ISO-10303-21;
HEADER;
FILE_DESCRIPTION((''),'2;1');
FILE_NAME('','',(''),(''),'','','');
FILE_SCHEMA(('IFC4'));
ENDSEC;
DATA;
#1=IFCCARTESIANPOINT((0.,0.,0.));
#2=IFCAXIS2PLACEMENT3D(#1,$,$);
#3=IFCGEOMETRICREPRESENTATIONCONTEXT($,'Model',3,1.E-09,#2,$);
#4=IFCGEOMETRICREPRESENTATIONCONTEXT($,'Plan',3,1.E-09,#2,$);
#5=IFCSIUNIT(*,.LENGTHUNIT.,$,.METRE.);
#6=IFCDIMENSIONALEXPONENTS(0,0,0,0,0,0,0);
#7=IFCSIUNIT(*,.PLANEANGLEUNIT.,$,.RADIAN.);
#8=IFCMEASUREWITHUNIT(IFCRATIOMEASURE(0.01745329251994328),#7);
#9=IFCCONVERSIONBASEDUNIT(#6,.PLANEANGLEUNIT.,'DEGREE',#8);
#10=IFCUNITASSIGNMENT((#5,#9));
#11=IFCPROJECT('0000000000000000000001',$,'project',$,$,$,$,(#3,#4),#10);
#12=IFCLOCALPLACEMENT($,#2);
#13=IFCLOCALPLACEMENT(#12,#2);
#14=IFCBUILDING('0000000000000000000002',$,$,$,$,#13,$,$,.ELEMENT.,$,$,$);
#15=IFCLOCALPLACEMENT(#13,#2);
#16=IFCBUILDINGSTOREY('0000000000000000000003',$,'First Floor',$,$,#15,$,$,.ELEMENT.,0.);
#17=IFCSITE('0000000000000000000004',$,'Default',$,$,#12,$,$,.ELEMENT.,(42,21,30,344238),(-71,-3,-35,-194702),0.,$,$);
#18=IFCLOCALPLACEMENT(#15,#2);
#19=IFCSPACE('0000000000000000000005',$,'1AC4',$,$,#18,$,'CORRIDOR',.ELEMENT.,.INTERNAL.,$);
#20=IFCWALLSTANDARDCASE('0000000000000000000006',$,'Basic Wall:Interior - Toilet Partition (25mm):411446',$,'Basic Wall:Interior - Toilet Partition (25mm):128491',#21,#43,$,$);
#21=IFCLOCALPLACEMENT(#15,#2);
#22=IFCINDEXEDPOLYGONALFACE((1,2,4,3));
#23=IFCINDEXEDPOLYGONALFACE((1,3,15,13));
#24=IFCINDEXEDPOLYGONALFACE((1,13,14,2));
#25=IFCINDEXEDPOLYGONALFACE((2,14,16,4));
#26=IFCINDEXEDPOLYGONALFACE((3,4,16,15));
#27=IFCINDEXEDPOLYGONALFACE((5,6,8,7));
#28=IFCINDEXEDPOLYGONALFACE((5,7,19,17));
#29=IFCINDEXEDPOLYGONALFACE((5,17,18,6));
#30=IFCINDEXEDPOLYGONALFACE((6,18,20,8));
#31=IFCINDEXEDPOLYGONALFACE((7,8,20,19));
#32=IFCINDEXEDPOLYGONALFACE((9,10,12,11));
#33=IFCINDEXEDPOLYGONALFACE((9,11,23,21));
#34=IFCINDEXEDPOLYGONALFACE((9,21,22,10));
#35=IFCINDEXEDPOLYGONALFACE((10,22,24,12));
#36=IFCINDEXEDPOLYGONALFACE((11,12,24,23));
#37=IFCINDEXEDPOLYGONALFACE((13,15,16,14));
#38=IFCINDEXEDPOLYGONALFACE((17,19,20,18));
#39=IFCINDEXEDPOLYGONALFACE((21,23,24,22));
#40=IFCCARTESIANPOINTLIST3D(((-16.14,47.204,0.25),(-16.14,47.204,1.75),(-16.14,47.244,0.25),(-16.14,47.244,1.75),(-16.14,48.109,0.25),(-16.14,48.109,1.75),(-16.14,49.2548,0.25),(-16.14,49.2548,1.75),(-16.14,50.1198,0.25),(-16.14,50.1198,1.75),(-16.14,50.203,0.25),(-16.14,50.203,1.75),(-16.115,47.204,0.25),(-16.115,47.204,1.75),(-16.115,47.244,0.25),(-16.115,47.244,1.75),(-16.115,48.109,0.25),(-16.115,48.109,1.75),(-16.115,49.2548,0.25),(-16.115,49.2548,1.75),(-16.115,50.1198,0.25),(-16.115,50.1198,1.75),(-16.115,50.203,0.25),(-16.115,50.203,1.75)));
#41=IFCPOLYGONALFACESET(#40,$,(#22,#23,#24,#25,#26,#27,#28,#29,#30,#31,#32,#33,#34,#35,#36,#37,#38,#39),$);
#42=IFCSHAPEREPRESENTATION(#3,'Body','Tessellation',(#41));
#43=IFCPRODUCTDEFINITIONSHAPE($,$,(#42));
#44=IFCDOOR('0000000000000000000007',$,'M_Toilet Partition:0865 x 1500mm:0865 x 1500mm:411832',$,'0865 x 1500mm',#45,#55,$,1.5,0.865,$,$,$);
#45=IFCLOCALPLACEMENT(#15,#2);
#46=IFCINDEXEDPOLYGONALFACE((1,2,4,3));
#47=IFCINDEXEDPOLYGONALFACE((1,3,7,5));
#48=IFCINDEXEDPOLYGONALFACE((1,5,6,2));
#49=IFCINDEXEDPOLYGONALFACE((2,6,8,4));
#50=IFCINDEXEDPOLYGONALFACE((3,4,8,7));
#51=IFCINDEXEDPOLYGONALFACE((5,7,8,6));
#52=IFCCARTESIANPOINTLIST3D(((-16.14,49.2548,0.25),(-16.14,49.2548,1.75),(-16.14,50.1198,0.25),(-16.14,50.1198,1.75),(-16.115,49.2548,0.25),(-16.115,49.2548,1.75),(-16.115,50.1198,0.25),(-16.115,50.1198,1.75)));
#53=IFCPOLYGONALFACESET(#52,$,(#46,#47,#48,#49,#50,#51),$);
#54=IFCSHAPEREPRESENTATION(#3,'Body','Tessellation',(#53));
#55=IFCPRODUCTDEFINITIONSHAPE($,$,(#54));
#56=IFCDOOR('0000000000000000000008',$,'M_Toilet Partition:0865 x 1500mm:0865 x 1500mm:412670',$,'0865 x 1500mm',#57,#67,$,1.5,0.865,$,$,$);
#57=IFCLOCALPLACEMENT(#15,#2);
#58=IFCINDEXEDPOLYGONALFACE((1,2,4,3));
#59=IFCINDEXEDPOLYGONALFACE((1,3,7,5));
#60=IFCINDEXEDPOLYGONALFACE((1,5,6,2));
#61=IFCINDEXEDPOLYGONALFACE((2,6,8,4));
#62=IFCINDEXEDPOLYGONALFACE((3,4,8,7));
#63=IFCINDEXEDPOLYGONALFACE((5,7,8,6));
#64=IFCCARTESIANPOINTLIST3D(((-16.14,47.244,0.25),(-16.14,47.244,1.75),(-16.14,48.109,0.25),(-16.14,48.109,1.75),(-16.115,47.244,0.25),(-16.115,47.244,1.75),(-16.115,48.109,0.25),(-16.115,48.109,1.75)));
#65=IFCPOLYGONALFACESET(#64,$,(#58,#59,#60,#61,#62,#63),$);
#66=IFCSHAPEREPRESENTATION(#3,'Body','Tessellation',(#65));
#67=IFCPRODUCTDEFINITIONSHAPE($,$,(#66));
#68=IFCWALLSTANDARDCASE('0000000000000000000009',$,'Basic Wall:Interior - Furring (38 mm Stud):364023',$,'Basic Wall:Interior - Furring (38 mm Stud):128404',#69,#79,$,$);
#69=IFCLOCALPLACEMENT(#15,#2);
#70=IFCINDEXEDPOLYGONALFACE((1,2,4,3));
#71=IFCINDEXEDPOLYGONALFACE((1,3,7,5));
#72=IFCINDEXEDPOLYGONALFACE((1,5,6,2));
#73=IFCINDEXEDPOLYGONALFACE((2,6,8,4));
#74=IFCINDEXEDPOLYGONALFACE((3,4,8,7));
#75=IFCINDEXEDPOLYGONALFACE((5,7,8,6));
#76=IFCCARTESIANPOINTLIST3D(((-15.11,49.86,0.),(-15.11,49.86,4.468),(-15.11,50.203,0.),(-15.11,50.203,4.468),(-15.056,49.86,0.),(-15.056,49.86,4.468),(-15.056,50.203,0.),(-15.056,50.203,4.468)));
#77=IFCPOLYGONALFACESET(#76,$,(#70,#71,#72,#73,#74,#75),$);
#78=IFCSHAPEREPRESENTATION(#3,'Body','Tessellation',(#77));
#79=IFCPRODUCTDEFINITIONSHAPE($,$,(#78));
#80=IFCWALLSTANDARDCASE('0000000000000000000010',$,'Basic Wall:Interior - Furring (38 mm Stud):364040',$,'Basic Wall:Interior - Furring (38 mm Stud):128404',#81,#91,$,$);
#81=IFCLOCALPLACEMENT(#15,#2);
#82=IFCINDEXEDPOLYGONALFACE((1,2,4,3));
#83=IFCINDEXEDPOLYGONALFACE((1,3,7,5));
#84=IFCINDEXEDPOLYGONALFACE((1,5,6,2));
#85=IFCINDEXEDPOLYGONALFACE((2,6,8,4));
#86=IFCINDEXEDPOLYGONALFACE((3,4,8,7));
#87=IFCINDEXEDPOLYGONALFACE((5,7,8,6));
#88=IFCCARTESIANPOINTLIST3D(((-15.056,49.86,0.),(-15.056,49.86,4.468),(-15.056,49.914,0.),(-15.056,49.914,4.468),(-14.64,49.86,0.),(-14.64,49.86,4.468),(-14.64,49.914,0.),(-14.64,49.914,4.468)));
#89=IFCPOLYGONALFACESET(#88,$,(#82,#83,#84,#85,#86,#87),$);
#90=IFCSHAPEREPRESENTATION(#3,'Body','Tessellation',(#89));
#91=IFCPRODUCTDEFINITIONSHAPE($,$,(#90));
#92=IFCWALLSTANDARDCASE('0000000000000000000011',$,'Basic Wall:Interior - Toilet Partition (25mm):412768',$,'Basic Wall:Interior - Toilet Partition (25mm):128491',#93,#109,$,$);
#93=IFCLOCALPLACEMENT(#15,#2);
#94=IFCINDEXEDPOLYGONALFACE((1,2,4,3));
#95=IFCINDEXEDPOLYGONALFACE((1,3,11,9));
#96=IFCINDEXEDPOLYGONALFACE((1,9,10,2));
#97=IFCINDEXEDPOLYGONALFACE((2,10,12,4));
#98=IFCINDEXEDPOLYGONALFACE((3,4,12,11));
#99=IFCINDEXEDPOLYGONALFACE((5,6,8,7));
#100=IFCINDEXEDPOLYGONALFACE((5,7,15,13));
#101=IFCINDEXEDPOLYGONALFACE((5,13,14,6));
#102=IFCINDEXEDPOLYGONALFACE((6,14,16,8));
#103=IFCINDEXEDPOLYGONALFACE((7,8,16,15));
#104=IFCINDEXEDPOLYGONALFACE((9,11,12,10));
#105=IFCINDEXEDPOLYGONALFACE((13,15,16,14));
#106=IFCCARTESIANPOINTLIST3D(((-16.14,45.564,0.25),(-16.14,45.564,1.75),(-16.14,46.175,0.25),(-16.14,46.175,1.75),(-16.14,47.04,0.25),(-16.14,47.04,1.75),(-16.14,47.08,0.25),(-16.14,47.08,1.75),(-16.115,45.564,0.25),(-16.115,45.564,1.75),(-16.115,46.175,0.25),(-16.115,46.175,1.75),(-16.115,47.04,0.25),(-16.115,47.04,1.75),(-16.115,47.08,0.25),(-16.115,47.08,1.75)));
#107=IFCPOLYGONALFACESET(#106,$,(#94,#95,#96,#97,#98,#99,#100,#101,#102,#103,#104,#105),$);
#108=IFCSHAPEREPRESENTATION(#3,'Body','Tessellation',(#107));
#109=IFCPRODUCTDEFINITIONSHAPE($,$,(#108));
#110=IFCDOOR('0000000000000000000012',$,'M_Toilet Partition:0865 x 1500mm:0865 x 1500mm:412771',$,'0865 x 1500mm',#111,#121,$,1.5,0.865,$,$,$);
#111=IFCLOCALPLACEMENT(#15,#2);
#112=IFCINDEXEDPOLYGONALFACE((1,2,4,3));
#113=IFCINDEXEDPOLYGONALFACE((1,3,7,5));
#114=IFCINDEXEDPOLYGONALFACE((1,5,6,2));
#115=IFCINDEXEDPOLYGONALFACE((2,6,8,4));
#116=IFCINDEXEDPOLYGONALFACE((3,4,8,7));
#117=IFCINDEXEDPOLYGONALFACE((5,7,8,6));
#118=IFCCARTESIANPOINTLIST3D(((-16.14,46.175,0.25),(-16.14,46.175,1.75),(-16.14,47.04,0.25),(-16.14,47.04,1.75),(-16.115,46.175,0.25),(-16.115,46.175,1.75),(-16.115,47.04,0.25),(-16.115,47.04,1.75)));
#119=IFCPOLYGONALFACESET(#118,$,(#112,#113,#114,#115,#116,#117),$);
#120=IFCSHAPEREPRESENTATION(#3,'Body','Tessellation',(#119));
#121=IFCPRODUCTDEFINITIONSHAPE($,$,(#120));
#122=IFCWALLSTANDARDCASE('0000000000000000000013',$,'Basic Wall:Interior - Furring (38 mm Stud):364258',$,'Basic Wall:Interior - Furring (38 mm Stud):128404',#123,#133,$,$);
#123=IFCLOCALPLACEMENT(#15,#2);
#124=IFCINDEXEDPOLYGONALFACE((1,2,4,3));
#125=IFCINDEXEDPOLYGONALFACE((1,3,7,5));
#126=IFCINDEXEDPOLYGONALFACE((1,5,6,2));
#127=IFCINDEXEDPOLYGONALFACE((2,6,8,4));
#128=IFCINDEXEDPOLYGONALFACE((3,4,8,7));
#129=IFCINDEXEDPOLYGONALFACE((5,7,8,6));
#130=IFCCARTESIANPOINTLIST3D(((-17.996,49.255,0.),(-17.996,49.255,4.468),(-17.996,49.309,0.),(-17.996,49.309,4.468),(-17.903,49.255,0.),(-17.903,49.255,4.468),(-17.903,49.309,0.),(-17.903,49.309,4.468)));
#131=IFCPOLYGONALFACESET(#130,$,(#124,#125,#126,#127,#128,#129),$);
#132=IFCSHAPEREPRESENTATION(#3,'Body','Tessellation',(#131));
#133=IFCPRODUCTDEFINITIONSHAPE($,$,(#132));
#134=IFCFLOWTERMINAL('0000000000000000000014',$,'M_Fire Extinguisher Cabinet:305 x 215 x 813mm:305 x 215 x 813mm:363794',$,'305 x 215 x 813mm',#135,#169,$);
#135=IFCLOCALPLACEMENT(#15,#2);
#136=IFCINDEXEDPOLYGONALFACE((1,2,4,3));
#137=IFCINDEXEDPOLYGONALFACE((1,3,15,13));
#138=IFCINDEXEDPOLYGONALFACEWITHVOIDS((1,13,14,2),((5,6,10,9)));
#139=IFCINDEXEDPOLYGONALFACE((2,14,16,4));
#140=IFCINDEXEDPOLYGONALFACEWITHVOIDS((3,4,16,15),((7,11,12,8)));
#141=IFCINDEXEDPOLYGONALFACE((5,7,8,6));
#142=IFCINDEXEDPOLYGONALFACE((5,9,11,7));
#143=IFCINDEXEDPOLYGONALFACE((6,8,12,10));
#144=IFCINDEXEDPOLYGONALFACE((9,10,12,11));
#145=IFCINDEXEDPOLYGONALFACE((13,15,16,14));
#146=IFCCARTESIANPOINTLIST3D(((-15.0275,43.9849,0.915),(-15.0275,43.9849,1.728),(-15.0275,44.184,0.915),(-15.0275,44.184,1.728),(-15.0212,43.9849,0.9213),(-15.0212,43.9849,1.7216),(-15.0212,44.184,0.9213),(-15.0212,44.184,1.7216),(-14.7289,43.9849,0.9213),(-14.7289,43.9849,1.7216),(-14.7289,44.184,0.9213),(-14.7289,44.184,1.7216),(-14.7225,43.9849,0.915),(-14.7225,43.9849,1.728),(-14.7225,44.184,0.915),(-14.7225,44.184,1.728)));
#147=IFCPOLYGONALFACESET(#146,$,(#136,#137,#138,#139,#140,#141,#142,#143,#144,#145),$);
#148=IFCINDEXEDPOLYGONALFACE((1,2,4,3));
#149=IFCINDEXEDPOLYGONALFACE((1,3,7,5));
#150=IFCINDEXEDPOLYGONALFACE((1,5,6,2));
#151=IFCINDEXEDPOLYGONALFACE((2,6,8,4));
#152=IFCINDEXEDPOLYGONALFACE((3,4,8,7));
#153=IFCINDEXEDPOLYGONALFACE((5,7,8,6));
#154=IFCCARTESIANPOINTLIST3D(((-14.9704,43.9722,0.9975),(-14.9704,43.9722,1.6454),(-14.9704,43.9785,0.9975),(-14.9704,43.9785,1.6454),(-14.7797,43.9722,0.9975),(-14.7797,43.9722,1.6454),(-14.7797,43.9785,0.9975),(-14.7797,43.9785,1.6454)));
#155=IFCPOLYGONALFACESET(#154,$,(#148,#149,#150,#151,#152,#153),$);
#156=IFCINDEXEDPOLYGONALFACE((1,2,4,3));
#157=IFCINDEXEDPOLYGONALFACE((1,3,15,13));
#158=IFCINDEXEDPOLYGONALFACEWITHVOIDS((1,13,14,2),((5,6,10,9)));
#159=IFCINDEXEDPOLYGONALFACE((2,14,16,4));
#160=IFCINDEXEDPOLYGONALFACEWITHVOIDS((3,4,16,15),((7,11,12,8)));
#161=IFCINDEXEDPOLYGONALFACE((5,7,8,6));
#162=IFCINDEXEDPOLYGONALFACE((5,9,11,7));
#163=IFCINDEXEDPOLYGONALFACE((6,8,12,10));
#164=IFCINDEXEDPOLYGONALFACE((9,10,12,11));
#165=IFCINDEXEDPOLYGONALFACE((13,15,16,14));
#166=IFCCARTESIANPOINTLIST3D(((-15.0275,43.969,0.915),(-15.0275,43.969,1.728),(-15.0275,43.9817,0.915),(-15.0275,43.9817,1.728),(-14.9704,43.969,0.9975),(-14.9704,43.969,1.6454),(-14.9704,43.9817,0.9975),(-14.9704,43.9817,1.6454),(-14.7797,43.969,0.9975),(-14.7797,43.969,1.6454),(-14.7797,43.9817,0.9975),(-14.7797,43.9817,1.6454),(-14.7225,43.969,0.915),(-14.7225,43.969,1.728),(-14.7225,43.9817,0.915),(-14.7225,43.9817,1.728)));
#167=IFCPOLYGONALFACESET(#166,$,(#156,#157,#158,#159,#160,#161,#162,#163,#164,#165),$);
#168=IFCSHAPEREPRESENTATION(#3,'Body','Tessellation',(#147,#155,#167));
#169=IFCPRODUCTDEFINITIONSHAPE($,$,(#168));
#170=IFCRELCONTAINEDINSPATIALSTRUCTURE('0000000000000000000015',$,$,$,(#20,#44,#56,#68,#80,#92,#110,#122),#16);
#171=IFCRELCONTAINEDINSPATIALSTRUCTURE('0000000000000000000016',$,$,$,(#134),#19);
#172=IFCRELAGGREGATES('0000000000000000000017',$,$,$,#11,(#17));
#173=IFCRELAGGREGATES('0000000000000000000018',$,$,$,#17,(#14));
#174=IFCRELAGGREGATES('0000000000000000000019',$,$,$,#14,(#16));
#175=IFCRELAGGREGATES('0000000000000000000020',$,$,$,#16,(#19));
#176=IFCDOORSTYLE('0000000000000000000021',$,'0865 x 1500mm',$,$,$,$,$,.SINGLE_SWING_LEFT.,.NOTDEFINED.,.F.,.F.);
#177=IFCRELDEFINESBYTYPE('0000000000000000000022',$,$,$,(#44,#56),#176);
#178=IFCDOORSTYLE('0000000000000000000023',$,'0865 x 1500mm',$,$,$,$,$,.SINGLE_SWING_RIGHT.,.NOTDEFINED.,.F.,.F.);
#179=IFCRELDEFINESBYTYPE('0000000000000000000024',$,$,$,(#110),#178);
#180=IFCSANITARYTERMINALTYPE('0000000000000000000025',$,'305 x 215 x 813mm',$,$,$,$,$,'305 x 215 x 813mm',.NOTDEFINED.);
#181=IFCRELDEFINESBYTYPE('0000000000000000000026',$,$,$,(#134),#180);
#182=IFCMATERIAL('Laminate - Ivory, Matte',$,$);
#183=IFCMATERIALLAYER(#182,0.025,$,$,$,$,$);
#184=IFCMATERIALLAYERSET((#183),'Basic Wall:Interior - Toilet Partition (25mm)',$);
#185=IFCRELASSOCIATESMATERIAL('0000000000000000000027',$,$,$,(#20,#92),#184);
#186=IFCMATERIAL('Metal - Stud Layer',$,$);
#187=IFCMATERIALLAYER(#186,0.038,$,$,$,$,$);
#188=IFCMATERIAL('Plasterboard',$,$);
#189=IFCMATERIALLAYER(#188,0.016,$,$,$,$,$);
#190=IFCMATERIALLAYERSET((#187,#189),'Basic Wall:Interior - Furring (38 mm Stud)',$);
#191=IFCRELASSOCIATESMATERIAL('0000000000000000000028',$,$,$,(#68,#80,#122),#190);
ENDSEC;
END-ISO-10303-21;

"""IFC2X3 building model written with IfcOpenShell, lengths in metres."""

from ifc_helpers import new_model, entity, si_unit, converted_unit, frame, frame_2d, origin, origin_2d_with_axis, place, context, project, spatial, polyline, rectangle, outline, extrude, source, transform, mapped, material, layer, layer_set, layer_usage, type_object, type_shapes, element, fill, save


model = new_model("IFC2X3")

# Units and contexts
model_context = context("Model", 3, precision=1e-09, world=origin())
plan_context = context("Plan", 3, precision=1e-09, world=origin())
ifc_project = project(units=[si_unit("LENGTHUNIT", "METRE"), converted_unit("PLANEANGLEUNIT", "DEGREE", entity("IfcRatioMeasure", 0.01745329251994328), si_unit("PLANEANGLEUNIT", "RADIAN"), dimensions=[0, 0, 0, 0, 0, 0, 0])], contexts=[model_context, plan_context])

# Site, building, storey
site_placement = place(None, origin())
site = spatial("IfcSite", under=ifc_project, at=site_placement, Name="Default", CompositionType="ELEMENT", RefLatitude=(42, 21, 30, 344238), RefLongitude=(-71, -3, -35, -194702), RefElevation=0.0)
building_placement = place(site_placement, origin())
building = spatial("IfcBuilding", under=site, at=building_placement, CompositionType="ELEMENT")
storey_placement = place(building_placement, origin())
storey = spatial("IfcBuildingStorey", under=building, at=storey_placement, Name="First Floor", CompositionType="ELEMENT", Elevation=0.0)

# Shared definitions
ifc_material_1 = material(Name="Metal - Stud Layer")
ifc_material_2 = material(Name="Plasterboard")
ifc_layer_1 = layer(ifc_material_2, 0.016)

# Shared definitions
ifc_layer_2 = layer(ifc_material_1, 0.038)
ifc_layer_set_1 = layer_set([ifc_layer_2, ifc_layer_1], Name="Basic Wall:Interior - Furring (38 mm Stud)")
ifc_layer_usage_1 = layer_usage(ifc_layer_set_1, "AXIS2", "NEGATIVE", 0.027)

# Wall, openings, doors
ifc_material_3 = material(Name="Laminate - Ivory, Matte")
ifc_layer_3 = layer(ifc_material_3, 0.025)
ifc_layer_set_2 = layer_set([ifc_layer_3], Name="Basic Wall:Interior - Toilet Partition (25mm)")
ifc_layer_usage_2 = layer_usage(ifc_layer_set_2, "AXIS2", "POSITIVE", -0.0125)
wall_1_placement = place(storey_placement, frame((-16.1275, 50.203, 0.25), z_axis=(0.0, 0.0, 1.0), x_axis=(0.0, -1.0, 0.0)))
wall_1 = element("IfcWallStandardCase", 1, at=wall_1_placement, inside=storey, material=ifc_layer_usage_2, Name="Basic Wall:Interior - Toilet Partition (25mm):411446", ObjectType="Basic Wall:Interior - Toilet Partition (25mm):128491", context=model_context, shape_type="SweptSolid", body=[
    extrude(rectangle(XDim=2.999, YDim=0.025, at=frame_2d((1.4995, 0.0), x_axis=(-1.0, 0.0))), origin(), (0.0, 0.0, 1.0), 1.5),
])
opening_1_placement = place(wall_1_placement, frame((0.0832, -0.0125, 0.0)))
opening_1 = element("IfcOpeningElement", 2, at=opening_1_placement, cuts=wall_1, ObjectType="Opening", context=model_context, shape_type="SweptSolid", body=[
    extrude(rectangle(XDim=0.865, YDim=1.5, at=frame_2d((0.75, 0.4325), x_axis=(0.0, -1.0))), frame((0.0, 0.0, 0.0), z_axis=(0.0, 1.0, 0.0), x_axis=(0.0, 0.0, 1.0)), (0.0, 0.0, 1.0), 0.025),
])
opening_2_placement = place(wall_1_placement, frame((2.959, 0.0125, 0.0)))
opening_2 = element("IfcOpeningElement", 3, at=opening_2_placement, cuts=wall_1, ObjectType="Opening", context=model_context, shape_type="SweptSolid", body=[
    extrude(rectangle(XDim=0.865, YDim=1.5, at=frame_2d((0.75, 0.4325), x_axis=(0.0, -1.0))), frame((0.0, 0.0, 0.0), z_axis=(0.0, -1.0, 0.0), x_axis=(0.0, 0.0, 1.0)), (0.0, 0.0, 1.0), 0.025),
])
door_style_1 = type_object("IfcDoorStyle", Name="0865 x 1500mm", ConstructionType="NOTDEFINED", OperationType="SINGLE_SWING_LEFT", ParameterTakesPrecedence=False, Sizeable=False)
shared_shape_1 = source(origin(), model_context, "Body", "SweptSolid", [
    extrude(rectangle(XDim=0.865, YDim=0.025, at=origin_2d_with_axis()), frame((0.4325, 0.0125, 0.0)), (0.0, 0.0, 1.0), 1.5),
])
type_shapes(door_style_1, [shared_shape_1])
door_1_placement = place(opening_1_placement, origin())
door_1 = element("IfcDoor", 4, at=door_1_placement, inside=storey, type_object=door_style_1, Name="M_Toilet Partition:0865 x 1500mm:0865 x 1500mm:411832", ObjectType="0865 x 1500mm", OverallHeight=1.5, OverallWidth=0.865, context=model_context, shape_type="MappedRepresentation", body=[
    mapped(shared_shape_1, transform((0.0, 0.0, 0.0), scale=1.0)),
])
fill(opening_1, door_1)
door_2_placement = place(opening_2_placement, frame((0.0, 0.0, 0.0), z_axis=(0.0, 0.0, 1.0), x_axis=(-1.0, 0.0, 0.0)))
door_2 = element("IfcDoor", 5, at=door_2_placement, inside=storey, type_object=door_style_1, Name="M_Toilet Partition:0865 x 1500mm:0865 x 1500mm:412670", ObjectType="0865 x 1500mm", OverallHeight=1.5, OverallWidth=0.865, context=model_context, shape_type="MappedRepresentation", body=[
    mapped(shared_shape_1, transform((0.0, 0.0, 0.0), scale=1.0)),
])
fill(opening_2, door_2)

# Walls
wall_2_placement = place(storey_placement, frame((-15.083, 50.203, 0.0), z_axis=(0.0, 0.0, 1.0), x_axis=(0.0, -1.0, 0.0)))
element("IfcWallStandardCase", 6, at=wall_2_placement, inside=storey, material=ifc_layer_usage_1, Name="Basic Wall:Interior - Furring (38 mm Stud):364023", ObjectType="Basic Wall:Interior - Furring (38 mm Stud):128404", context=model_context, shape_type="SweptSolid", body=[
    extrude(rectangle(XDim=0.343, YDim=0.054, at=frame_2d((0.1715, 0.0), x_axis=(-1.0, 0.0))), origin(), (0.0, 0.0, 1.0), 4.468),
])
wall_3_placement = place(storey_placement, frame((-15.056, 49.887, 0.0)))
element("IfcWallStandardCase", 7, at=wall_3_placement, inside=storey, material=ifc_layer_usage_1, Name="Basic Wall:Interior - Furring (38 mm Stud):364040", ObjectType="Basic Wall:Interior - Furring (38 mm Stud):128404", context=model_context, shape_type="SweptSolid", body=[
    extrude(rectangle(XDim=0.416, YDim=0.054, at=frame_2d((0.208, 0.0), x_axis=(-1.0, 0.0))), origin(), (0.0, 0.0, 1.0), 4.468),
])

# Wall, opening, door
ifc_layer_usage_3 = layer_usage(ifc_layer_set_2, "AXIS2", "NEGATIVE", 0.0125)
wall_4_placement = place(storey_placement, frame((-16.1275, 45.564, 0.25), z_axis=(0.0, 0.0, 1.0), x_axis=(0.0, 1.0, 0.0)))
wall_4 = element("IfcWallStandardCase", 8, at=wall_4_placement, inside=storey, material=ifc_layer_usage_3, Name="Basic Wall:Interior - Toilet Partition (25mm):412768", ObjectType="Basic Wall:Interior - Toilet Partition (25mm):128491", context=model_context, shape_type="SweptSolid", body=[
    extrude(rectangle(XDim=1.516, YDim=0.025, at=frame_2d((0.758, 0.0), x_axis=(-1.0, 0.0))), origin(), (0.0, 0.0, 1.0), 1.5),
])
opening_3_placement = place(wall_4_placement, frame((0.611, -0.0125, 0.0)))
opening_3 = element("IfcOpeningElement", 9, at=opening_3_placement, cuts=wall_4, ObjectType="Opening", context=model_context, shape_type="SweptSolid", body=[
    extrude(rectangle(XDim=0.865, YDim=1.5, at=frame_2d((0.75, 0.4325), x_axis=(0.0, 1.0))), frame((0.0, 0.0, 0.0), z_axis=(0.0, 1.0, 0.0), x_axis=(0.0, 0.0, 1.0)), (0.0, 0.0, 1.0), 0.025),
])
door_style_2 = type_object("IfcDoorStyle", Name="0865 x 1500mm", ConstructionType="NOTDEFINED", OperationType="SINGLE_SWING_RIGHT", ParameterTakesPrecedence=False, Sizeable=False)
shared_shape_2 = source(origin(), model_context, "Body", "SweptSolid", [
    extrude(rectangle(XDim=0.025, YDim=0.865, at=origin_2d_with_axis()), frame((0.4325, 0.0125, 0.0), z_axis=(0.0, 0.0, 1.0), x_axis=(0.0, 1.0, 0.0)), (0.0, 0.0, 1.0), 1.5),
])
type_shapes(door_style_2, [shared_shape_2])
door_3_placement = place(opening_3_placement, origin())
door_3 = element("IfcDoor", 10, at=door_3_placement, inside=storey, type_object=door_style_2, Name="M_Toilet Partition:0865 x 1500mm:0865 x 1500mm:412771", ObjectType="0865 x 1500mm", OverallHeight=1.5, OverallWidth=0.865, context=model_context, shape_type="MappedRepresentation", body=[
    mapped(shared_shape_2, transform((0.0, 0.0, 0.0), scale=1.0)),
])
fill(opening_3, door_3)

# Wall
wall_5_placement = place(storey_placement, frame((-17.996, 49.282, 0.0)))
element("IfcWallStandardCase", 11, at=wall_5_placement, inside=storey, material=ifc_layer_usage_1, Name="Basic Wall:Interior - Furring (38 mm Stud):364258", ObjectType="Basic Wall:Interior - Furring (38 mm Stud):128404", context=model_context, shape_type="SweptSolid", body=[
    extrude(rectangle(XDim=0.093, YDim=0.054, at=frame_2d((0.0465, 0.0), x_axis=(-1.0, 0.0))), origin(), (0.0, 0.0, 1.0), 4.468),
])

# Shared definitions
space_1_placement = place(storey_placement, origin())
space_1 = spatial("IfcSpace", under=storey, at=space_1_placement, Name="1AC4", LongName="CORRIDOR", CompositionType="ELEMENT", InteriorOrExteriorSpace="INTERNAL")

# Flow terminal
sanitary_terminal_type_1 = type_object("IfcSanitaryTerminalType", Name="305 x 215 x 813mm", ElementType="305 x 215 x 813mm", PredefinedType="NOTDEFINED")
shared_shape_3 = source(origin(), model_context, "Body", "SweptSolid", [
    extrude(outline(polyline([(-0.1525, -0.4065), (0.1525, -0.4065), (0.1525, 0.4065), (-0.1525, 0.4065), (-0.1525, -0.4065)]), holes=[polyline([(-0.1462, -0.4001), (-0.1462, 0.4002), (0.1462, 0.4002), (0.1462, -0.4001), (-0.1462, -0.4001)])]), frame((-0.1096, 0.027, 1.3215), z_axis=(0.0, 1.0, 0.0), x_axis=(1.0, 0.0, 0.0)), (0.0, 0.0, 1.0), 0.1991),
    extrude(rectangle(XDim=0.0064, YDim=0.1907, at=origin_2d_with_axis()), frame((-0.1096, 0.2356, 0.9975), z_axis=(0.0, 0.0, 1.0), x_axis=(0.0, -1.0, 0.0)), (0.0, 0.0, 1.0), 0.6479),
    extrude(outline(polyline([(-0.1525, -0.4065), (0.1525, -0.4065), (0.1525, 0.4065), (-0.1525, 0.4065), (-0.1525, -0.4065)]), holes=[polyline([(-0.0953, -0.3239), (-0.0953, 0.324), (0.0954, 0.324), (0.0954, -0.3239), (-0.0953, -0.3239)])]), frame((-0.1096, 0.2293, 1.3215), z_axis=(0.0, 1.0, 0.0), x_axis=(1.0, 0.0, 0.0)), (0.0, 0.0, 1.0), 0.0127),
])
type_shapes(sanitary_terminal_type_1, [shared_shape_3])
flow_terminal_1_placement = place(space_1_placement, frame((-14.9846, 44.211, 0.0), z_axis=(0.0, 0.0, 1.0), x_axis=(-1.0, 0.0, 0.0)))
element("IfcFlowTerminal", 12, at=flow_terminal_1_placement, inside=space_1, type_object=sanitary_terminal_type_1, Name="M_Fire Extinguisher Cabinet:305 x 215 x 813mm:305 x 215 x 813mm:363794", ObjectType="305 x 215 x 813mm", context=model_context, shape_type="MappedRepresentation", body=[
    mapped(shared_shape_3, transform((0.0, 0.0, 0.0), scale=1.0)),
])

save(model, "model.ifc")
